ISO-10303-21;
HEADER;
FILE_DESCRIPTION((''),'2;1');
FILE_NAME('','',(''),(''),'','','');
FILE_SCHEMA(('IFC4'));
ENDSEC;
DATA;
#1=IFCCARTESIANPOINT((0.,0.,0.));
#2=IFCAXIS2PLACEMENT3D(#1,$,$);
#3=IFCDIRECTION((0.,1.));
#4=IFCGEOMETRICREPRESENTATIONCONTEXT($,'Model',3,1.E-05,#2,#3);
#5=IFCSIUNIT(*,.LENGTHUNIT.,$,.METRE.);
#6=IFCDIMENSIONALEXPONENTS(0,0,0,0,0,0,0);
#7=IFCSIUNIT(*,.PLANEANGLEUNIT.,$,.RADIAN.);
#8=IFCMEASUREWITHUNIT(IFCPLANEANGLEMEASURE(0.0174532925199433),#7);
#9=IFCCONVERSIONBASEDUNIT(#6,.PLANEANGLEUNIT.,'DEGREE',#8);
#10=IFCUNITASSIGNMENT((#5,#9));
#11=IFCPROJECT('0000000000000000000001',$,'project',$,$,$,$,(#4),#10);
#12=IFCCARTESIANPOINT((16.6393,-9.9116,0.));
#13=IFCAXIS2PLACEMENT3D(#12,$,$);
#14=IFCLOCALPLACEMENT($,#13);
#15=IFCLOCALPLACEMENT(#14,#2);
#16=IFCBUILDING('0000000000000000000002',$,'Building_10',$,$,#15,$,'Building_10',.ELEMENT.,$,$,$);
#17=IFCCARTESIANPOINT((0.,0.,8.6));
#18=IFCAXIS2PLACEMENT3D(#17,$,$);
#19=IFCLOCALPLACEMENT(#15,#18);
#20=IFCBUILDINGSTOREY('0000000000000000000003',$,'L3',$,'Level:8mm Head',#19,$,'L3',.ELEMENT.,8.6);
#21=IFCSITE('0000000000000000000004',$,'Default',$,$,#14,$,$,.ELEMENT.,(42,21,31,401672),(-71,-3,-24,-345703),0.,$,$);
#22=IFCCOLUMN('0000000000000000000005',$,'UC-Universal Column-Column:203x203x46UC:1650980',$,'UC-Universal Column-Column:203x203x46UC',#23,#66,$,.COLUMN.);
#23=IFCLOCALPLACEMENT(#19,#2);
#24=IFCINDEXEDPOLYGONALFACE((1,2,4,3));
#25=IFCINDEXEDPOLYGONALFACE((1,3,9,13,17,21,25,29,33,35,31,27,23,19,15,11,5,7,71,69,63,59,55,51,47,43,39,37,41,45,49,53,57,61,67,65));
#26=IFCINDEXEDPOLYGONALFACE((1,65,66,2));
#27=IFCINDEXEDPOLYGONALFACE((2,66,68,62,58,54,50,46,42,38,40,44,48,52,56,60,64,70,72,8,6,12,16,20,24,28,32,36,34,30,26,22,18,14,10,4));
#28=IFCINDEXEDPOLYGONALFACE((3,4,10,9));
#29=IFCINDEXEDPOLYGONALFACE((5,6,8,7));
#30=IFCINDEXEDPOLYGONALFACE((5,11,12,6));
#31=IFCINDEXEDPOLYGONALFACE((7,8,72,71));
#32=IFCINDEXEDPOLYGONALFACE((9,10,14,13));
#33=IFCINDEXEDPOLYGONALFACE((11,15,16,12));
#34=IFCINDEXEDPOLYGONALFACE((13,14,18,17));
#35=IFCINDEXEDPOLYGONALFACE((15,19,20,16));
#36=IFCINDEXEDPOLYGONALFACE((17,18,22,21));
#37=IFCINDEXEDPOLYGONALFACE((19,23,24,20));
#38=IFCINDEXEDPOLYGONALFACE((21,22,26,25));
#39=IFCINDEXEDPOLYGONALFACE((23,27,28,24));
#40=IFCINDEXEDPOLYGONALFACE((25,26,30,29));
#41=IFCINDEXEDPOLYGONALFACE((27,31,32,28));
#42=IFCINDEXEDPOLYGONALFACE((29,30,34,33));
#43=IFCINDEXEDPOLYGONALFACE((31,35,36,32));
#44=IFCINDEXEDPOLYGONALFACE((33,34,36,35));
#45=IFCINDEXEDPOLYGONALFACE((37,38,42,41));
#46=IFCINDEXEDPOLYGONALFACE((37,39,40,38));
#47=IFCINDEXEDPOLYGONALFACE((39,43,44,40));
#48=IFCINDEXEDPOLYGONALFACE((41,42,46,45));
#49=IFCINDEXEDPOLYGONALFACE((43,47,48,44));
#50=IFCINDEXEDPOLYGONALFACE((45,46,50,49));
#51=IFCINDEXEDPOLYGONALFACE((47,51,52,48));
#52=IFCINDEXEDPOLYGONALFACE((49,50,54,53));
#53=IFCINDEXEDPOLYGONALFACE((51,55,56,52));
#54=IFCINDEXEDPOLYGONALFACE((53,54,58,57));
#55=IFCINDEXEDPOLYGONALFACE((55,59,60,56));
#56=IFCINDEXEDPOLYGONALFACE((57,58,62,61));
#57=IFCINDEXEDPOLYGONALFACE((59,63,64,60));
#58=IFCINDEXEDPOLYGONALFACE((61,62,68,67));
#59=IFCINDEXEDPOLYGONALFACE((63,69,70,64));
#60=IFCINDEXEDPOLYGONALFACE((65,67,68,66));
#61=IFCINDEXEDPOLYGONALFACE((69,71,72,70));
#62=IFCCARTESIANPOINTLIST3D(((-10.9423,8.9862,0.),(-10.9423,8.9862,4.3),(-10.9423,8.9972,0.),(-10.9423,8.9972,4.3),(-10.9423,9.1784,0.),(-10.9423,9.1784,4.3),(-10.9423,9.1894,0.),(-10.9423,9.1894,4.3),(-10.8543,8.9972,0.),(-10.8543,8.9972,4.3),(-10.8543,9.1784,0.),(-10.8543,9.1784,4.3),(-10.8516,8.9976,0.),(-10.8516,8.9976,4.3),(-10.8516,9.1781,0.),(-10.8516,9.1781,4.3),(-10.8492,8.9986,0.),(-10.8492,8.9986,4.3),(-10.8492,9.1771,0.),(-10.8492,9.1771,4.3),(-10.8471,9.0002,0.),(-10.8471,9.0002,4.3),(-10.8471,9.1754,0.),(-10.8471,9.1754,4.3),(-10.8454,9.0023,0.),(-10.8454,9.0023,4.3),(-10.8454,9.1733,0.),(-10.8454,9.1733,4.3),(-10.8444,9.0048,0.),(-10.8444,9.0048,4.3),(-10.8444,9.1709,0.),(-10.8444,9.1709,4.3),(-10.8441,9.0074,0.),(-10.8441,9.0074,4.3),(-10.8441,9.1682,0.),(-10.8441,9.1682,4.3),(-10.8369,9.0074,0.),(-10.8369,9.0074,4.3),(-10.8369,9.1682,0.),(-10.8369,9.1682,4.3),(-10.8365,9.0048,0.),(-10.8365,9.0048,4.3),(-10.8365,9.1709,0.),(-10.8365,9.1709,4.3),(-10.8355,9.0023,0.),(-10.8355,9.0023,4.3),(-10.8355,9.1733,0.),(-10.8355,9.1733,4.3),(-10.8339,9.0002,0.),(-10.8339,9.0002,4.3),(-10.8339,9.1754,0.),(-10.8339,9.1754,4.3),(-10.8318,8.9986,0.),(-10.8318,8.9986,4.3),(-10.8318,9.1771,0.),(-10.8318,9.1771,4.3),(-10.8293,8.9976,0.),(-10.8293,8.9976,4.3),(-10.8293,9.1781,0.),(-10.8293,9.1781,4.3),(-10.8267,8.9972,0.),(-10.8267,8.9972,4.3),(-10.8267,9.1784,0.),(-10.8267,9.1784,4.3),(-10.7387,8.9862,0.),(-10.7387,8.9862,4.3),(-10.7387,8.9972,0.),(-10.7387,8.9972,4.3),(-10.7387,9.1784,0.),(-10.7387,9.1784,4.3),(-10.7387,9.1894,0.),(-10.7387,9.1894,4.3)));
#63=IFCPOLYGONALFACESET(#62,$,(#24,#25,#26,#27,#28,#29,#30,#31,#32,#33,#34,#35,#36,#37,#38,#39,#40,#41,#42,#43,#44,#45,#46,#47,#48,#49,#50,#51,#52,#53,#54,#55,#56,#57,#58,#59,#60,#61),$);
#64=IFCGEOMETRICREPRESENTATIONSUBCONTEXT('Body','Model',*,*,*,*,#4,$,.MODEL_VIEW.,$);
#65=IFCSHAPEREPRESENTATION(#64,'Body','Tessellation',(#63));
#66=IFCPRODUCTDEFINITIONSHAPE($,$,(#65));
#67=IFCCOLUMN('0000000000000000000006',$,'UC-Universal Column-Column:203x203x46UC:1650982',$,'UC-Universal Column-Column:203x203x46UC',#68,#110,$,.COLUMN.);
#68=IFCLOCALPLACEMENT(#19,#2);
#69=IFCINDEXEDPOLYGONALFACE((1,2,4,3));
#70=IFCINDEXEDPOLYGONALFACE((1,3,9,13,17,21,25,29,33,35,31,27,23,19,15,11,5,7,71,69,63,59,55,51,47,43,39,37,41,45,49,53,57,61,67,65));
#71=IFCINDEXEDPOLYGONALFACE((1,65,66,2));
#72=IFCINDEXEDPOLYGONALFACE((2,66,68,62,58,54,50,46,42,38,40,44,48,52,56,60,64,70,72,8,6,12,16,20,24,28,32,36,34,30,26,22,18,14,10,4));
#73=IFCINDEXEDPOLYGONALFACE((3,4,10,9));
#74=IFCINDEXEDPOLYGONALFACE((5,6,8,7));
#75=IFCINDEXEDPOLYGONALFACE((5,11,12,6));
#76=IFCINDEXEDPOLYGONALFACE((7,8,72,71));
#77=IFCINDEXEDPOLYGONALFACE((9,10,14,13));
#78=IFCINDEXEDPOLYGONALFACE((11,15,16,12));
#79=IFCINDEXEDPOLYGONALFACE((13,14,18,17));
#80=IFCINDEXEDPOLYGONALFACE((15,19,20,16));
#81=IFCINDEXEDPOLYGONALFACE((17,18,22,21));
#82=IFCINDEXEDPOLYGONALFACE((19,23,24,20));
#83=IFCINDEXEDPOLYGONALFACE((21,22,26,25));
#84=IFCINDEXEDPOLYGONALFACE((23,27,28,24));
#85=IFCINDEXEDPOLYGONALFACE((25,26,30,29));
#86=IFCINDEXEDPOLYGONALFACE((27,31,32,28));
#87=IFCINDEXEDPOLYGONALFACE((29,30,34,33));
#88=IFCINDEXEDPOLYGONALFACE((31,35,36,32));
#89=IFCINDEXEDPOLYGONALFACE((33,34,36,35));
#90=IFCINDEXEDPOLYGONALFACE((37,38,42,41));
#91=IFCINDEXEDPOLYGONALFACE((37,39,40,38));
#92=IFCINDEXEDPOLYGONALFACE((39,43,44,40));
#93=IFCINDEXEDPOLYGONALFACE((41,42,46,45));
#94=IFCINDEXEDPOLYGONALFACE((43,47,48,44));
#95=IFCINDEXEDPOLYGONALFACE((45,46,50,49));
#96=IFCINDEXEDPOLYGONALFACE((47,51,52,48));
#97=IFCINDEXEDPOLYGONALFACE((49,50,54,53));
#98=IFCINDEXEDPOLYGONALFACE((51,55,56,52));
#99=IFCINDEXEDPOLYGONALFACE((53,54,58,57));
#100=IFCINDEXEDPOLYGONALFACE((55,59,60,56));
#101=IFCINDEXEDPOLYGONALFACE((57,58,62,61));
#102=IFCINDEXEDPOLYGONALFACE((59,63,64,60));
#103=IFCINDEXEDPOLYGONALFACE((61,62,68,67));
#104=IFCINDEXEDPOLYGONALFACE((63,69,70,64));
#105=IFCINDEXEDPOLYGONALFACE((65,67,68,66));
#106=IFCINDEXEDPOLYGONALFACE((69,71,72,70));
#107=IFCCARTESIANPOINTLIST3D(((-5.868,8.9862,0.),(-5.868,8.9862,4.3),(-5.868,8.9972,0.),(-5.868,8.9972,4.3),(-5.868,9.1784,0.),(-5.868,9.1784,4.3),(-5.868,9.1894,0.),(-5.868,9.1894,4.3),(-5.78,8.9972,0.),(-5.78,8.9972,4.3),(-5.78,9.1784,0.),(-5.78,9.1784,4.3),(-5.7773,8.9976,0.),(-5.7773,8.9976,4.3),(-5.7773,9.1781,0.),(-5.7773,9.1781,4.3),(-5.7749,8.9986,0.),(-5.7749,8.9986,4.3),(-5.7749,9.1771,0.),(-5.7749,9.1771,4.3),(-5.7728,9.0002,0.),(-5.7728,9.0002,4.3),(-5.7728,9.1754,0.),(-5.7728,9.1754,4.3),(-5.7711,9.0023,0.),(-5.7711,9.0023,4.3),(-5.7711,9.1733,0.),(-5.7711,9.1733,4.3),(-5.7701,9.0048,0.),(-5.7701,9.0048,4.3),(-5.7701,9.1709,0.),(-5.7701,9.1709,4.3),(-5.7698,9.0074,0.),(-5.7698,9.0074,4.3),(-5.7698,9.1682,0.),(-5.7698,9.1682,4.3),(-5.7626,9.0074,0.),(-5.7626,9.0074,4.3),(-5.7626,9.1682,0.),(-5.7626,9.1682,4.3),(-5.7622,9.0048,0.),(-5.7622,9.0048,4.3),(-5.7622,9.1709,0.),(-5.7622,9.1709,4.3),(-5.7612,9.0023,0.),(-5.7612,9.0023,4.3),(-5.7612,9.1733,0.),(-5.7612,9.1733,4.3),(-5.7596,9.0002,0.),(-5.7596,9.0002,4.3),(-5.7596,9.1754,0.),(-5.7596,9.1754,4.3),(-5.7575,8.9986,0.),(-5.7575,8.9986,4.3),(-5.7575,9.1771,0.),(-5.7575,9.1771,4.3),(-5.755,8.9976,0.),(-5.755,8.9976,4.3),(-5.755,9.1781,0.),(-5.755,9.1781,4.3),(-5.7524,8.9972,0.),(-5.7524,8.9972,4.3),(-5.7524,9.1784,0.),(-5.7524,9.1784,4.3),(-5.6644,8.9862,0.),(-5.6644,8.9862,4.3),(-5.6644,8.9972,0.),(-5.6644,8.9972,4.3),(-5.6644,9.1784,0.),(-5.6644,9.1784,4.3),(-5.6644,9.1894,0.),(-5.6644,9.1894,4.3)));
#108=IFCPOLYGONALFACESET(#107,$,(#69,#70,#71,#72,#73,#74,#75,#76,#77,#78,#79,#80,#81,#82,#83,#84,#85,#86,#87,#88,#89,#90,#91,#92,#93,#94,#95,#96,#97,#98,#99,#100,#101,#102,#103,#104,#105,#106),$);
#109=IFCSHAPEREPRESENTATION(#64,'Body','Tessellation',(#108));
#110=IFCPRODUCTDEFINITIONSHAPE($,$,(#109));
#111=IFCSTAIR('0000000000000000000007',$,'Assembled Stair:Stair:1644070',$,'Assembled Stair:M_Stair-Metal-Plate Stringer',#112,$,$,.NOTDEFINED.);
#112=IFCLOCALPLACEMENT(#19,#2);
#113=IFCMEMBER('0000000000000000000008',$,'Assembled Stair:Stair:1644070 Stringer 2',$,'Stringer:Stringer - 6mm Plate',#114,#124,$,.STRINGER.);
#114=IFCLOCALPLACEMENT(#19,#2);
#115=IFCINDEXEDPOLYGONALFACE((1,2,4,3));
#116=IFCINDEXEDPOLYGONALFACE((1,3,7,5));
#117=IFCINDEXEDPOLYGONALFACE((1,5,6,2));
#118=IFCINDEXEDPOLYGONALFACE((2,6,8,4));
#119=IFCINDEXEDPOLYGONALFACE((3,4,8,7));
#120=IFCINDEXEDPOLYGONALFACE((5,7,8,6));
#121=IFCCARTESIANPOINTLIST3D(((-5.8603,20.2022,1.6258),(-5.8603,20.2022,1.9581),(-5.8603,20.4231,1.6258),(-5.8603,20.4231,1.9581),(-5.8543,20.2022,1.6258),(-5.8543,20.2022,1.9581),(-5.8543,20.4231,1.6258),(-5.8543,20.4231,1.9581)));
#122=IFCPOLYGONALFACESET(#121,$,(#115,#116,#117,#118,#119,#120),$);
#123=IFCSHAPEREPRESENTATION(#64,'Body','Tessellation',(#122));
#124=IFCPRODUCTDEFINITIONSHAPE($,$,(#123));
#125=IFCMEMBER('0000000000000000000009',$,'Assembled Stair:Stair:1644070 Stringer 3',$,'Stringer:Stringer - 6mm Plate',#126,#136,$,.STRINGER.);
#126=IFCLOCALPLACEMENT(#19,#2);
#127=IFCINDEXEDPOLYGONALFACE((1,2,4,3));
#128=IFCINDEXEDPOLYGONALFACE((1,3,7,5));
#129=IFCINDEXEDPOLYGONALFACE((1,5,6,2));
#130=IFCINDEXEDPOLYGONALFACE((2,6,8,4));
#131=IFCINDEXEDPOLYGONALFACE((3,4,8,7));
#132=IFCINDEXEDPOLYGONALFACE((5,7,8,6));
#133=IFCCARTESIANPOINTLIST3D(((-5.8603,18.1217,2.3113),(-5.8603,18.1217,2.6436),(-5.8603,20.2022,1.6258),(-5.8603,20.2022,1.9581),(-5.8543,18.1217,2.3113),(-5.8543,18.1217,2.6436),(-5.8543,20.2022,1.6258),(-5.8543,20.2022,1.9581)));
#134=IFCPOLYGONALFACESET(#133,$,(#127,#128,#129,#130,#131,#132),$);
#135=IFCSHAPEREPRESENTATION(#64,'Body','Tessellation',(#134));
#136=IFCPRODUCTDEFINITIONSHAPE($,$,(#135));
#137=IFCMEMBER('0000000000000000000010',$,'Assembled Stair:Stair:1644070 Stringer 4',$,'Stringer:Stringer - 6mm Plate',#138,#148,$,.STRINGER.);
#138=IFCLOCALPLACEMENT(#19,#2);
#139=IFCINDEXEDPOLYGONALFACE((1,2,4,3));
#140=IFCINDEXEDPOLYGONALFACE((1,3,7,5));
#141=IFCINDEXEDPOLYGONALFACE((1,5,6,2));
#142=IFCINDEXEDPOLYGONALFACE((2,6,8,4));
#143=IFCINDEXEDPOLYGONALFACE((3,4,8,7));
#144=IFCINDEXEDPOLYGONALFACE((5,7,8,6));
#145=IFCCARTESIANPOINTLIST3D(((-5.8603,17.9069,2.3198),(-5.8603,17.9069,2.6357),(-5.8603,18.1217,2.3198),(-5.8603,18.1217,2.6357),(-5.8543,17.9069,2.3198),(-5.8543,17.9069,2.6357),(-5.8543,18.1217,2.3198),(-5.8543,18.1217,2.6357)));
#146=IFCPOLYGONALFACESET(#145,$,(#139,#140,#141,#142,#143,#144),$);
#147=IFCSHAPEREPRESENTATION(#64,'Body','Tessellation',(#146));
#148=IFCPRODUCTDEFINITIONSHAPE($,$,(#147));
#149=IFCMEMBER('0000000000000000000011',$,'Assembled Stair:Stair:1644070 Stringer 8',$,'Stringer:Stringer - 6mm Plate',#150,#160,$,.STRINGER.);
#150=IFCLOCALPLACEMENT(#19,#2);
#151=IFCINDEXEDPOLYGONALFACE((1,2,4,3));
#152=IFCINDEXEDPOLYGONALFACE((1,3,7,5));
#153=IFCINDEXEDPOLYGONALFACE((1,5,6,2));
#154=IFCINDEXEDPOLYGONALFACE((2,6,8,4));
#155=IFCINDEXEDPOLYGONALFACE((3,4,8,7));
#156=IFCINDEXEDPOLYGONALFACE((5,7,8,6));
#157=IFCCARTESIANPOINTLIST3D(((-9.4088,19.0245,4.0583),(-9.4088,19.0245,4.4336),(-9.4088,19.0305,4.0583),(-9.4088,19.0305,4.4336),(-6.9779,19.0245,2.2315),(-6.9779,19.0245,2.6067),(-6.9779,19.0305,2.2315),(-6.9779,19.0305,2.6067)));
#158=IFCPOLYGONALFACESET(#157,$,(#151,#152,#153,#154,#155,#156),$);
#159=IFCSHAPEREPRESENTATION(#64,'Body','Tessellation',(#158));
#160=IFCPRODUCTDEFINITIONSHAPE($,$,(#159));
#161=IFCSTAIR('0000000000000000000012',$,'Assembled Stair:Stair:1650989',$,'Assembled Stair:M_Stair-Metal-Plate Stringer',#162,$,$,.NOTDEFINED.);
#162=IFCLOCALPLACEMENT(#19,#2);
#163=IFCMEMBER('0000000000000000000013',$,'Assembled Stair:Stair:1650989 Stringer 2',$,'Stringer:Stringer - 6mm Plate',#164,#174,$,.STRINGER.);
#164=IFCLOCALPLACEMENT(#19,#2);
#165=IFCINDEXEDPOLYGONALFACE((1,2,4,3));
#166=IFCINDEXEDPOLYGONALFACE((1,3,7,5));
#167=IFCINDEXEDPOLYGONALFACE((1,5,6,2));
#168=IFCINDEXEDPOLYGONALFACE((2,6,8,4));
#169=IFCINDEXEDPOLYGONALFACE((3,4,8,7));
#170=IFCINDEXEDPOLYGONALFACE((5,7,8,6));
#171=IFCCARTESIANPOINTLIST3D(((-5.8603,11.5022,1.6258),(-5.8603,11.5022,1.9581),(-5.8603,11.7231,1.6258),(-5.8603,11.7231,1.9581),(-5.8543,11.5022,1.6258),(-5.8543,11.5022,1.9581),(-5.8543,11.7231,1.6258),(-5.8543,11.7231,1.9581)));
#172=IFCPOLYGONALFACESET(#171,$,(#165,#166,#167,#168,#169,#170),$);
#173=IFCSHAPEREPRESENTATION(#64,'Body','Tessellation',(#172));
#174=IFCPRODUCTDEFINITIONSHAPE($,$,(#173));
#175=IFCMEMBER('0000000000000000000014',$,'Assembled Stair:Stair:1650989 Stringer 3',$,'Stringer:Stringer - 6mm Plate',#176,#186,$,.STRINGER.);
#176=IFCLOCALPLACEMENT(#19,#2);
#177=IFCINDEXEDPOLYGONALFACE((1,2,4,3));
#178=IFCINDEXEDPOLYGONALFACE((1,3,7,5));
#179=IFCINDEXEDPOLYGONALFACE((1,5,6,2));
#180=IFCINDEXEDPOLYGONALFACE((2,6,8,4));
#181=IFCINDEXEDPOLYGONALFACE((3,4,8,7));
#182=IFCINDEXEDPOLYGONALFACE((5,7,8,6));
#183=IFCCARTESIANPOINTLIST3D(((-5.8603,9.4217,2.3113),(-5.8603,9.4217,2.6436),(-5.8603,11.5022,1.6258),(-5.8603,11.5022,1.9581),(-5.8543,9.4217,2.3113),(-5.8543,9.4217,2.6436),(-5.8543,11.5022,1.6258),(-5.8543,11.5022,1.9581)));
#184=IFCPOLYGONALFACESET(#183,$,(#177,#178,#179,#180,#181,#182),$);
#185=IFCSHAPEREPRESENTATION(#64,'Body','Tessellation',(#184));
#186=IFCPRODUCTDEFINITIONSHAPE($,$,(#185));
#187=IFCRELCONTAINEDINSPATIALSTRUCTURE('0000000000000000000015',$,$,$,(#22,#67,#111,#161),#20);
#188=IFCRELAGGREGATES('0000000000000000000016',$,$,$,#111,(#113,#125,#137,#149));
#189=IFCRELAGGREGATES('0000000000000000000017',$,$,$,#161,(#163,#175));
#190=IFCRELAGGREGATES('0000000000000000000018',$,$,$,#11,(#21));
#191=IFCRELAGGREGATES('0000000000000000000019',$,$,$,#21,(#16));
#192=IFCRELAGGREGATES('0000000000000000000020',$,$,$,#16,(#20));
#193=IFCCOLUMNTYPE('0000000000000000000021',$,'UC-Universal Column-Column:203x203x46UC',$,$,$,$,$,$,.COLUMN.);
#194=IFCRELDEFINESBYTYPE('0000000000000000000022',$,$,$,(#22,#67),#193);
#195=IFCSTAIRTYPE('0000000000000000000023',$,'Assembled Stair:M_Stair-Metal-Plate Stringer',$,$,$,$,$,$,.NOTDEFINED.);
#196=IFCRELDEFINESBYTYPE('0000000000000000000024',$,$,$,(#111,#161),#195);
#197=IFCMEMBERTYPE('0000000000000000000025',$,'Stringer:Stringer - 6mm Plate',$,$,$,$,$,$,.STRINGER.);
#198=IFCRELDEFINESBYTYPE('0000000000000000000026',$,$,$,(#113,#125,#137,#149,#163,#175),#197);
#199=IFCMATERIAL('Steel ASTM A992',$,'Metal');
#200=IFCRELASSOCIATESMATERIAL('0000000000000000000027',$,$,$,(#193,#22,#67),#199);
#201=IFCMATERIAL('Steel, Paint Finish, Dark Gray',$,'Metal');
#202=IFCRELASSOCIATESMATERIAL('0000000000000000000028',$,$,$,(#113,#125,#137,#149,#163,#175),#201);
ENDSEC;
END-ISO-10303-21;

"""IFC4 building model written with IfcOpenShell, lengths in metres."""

from ifc_helpers import new_model, entity, si_unit, converted_unit, direction, frame, origin, place, context, subcontext, project, spatial, line, arc, indexed_curve, outline, extrude, source, transform, mapped, material, type_object, type_shapes, element, aggregate, save


model = new_model("IFC4")

# Units and contexts
model_context = context("Model", 3, precision=1e-05, world=origin(), true_north=direction((0.0, 1.0)))
body_context = subcontext(model_context, "Body", "Model", "MODEL_VIEW")
ifc_project = project(units=[si_unit("LENGTHUNIT", "METRE"), converted_unit("PLANEANGLEUNIT", "DEGREE", entity("IfcPlaneAngleMeasure", 0.0174532925199433), si_unit("PLANEANGLEUNIT", "RADIAN"), dimensions=[0, 0, 0, 0, 0, 0, 0])], contexts=[model_context])

# Site, building, storey
site_placement = place(None, frame((16.6393, -9.9116, 0.0)))
site = spatial("IfcSite", under=ifc_project, at=site_placement, Name="Default", CompositionType="ELEMENT", RefLatitude=(42, 21, 31, 401672), RefLongitude=(-71, -3, -24, -345703), RefElevation=0.0)
building_placement = place(site_placement, origin())
building = spatial("IfcBuilding", under=site, at=building_placement, Name="Building_10", LongName="Building_10", CompositionType="ELEMENT")
storey_placement = place(building_placement, frame((0.0, 0.0, 8.6)))
storey = spatial("IfcBuildingStorey", under=building, at=storey_placement, Name="L3", ObjectType="Level:8mm Head", LongName="L3", CompositionType="ELEMENT", Elevation=8.6)

# Columns
ifc_material_1 = material(Name="Steel ASTM A992", Category="Metal")
column_type = type_object("IfcColumnType", Name="UC-Universal Column-Column:203x203x46UC", PredefinedType="COLUMN", material=ifc_material_1)
shared_shape_1 = source(origin(), body_context, "Body", "SweptSolid", [
    extrude(outline(indexed_curve([(-0.1018, -0.1016), (0.1018, -0.1016), (0.1018, -0.0906), (0.0138, -0.0906), (0.0066, -0.0876), (0.0036, -0.0804), (0.0036, 0.0804), (0.0066, 0.0876), (0.0138, 0.0906), (0.1018, 0.0906), (0.1018, 0.1016), (-0.1018, 0.1016), (-0.1018, 0.0906), (-0.0138, 0.0906), (-0.0066, 0.0876), (-0.0036, 0.0804), (-0.0036, -0.0804), (-0.0066, -0.0876), (-0.0138, -0.0906), (-0.1018, -0.0906)], segments=[line(1, 2, 3, 4), arc(4, 5, 6), line(6, 7), arc(7, 8, 9), line(9, 10, 11, 12, 13, 14), arc(14, 15, 16), line(16, 17), arc(17, 18, 19), line(19, 20, 1)], self_intersect=False)), frame((0.0, 0.0, 8.6), z_axis=(0.0, 0.0, 1.0), x_axis=(-1.0, 0.0, 0.0)), (0.0, 0.0, 1.0), 4.3),
])
type_shapes(column_type, [shared_shape_1])
for number, where, name in (
    (1, (-10.8405, 9.0878, -8.6), "UC-Universal Column-Column:203x203x46UC:1650980"),
    (2, (-5.7662, 9.0878, -8.6), "UC-Universal Column-Column:203x203x46UC:1650982"),
):
    element("IfcColumn", number, at=place(storey_placement, frame(where)), inside=storey, type_object=column_type, material=ifc_material_1, Name=name, ObjectType="UC-Universal Column-Column:203x203x46UC", PredefinedType="COLUMN", context=body_context, shape_type="MappedRepresentation", body=[
        mapped(shared_shape_1, transform((0.0, 0.0, 0.0), scale=1.0)),
    ])

# Stairs, members
stair_type = type_object("IfcStairType", Name="Assembled Stair:M_Stair-Metal-Plate Stringer", PredefinedType="NOTDEFINED")
stair_1_placement = place(storey_placement, origin())
stair_1 = element("IfcStair", 3, at=stair_1_placement, inside=storey, type_object=stair_type, Name="Assembled Stair:Stair:1644070", ObjectType="Assembled Stair:M_Stair-Metal-Plate Stringer", PredefinedType="NOTDEFINED")
ifc_material_2 = material(Name="Steel, Paint Finish, Dark Gray", Category="Metal")
member_type = type_object("IfcMemberType", Name="Stringer:Stringer - 6mm Plate", PredefinedType="STRINGER")
member_1_placement = place(stair_1_placement, origin())
member_1 = element("IfcMember", 4, at=member_1_placement, type_object=member_type, material=ifc_material_2, Name="Assembled Stair:Stair:1644070 Stringer 2", ObjectType="Stringer:Stringer - 6mm Plate", PredefinedType="STRINGER", context=body_context, shape_type="SweptSolid", body=[
    extrude(outline(indexed_curve([(-0.1104, -0.003), (0.1104, -0.003), (0.1104, 0.003), (-0.1104, 0.003), (-0.1104, -0.003)], self_intersect=False)), frame((-5.8573, 20.3126, 1.6258), z_axis=(0.0, 0.0, 1.0), x_axis=(0.0, -1.0, 0.0)), (0.0, 0.0, 1.0), 0.3323),
])
member_2_placement = place(stair_1_placement, origin())
member_2 = element("IfcMember", 5, at=member_2_placement, type_object=member_type, material=ifc_material_2, Name="Assembled Stair:Stair:1644070 Stringer 3", ObjectType="Stringer:Stringer - 6mm Plate", PredefinedType="STRINGER", context=body_context, shape_type="SweptSolid", body=[
    extrude(outline(indexed_curve([(-1.0433, -0.1578), (1.1473, -0.1578), (1.0433, 0.1578), (-1.1473, 0.1578), (-1.0433, -0.1578)], self_intersect=False)), frame((-5.8603, 19.162, 2.1347), z_axis=(1.0, 0.0, 0.0), x_axis=(0.0, -0.949774, 0.312936)), (0.0, 0.0, 1.0), 0.006),
])
member_3_placement = place(stair_1_placement, origin())
member_3 = element("IfcMember", 6, at=member_3_placement, type_object=member_type, material=ifc_material_2, Name="Assembled Stair:Stair:1644070 Stringer 4", ObjectType="Stringer:Stringer - 6mm Plate", PredefinedType="STRINGER", context=body_context, shape_type="SweptSolid", body=[
    extrude(outline(indexed_curve([(-0.1074, -0.003), (0.1074, -0.003), (0.1074, 0.003), (-0.1074, 0.003), (-0.1074, -0.003)], self_intersect=False)), frame((-5.8573, 18.0143, 2.3198), z_axis=(0.0, 0.0, 1.0), x_axis=(0.0, -1.0, 0.0)), (0.0, 0.0, 1.0), 0.3159),
])
member_4_placement = place(stair_1_placement, origin())
member_4 = element("IfcMember", 7, at=member_4_placement, type_object=member_type, material=ifc_material_2, Name="Assembled Stair:Stair:1644070 Stringer 8", ObjectType="Stringer:Stringer - 6mm Plate", PredefinedType="STRINGER", context=body_context, shape_type="SweptSolid", body=[
    extrude(outline(indexed_curve([(-1.6331, -0.15), (1.4077, -0.15), (1.6331, 0.15), (-1.4077, 0.15), (-1.6331, -0.15)], self_intersect=False)), frame((-8.1933, 19.0245, 3.3325), z_axis=(0.0, 1.0, 0.0), x_axis=(-0.799415, 0.0, 0.600779)), (0.0, 0.0, 1.0), 0.006),
])
aggregate(stair_1, [member_1, member_2, member_3, member_4])
stair_2_placement = place(storey_placement, origin())
stair_2 = element("IfcStair", 8, at=stair_2_placement, inside=storey, type_object=stair_type, Name="Assembled Stair:Stair:1650989", ObjectType="Assembled Stair:M_Stair-Metal-Plate Stringer", PredefinedType="NOTDEFINED")
member_5_placement = place(stair_2_placement, origin())
member_5 = element("IfcMember", 9, at=member_5_placement, type_object=member_type, material=ifc_material_2, Name="Assembled Stair:Stair:1650989 Stringer 2", ObjectType="Stringer:Stringer - 6mm Plate", PredefinedType="STRINGER", context=body_context, shape_type="SweptSolid", body=[
    extrude(outline(indexed_curve([(-0.1104, -0.003), (0.1104, -0.003), (0.1104, 0.003), (-0.1104, 0.003), (-0.1104, -0.003)], self_intersect=False)), frame((-5.8573, 11.6126, 1.6258), z_axis=(0.0, 0.0, 1.0), x_axis=(0.0, -1.0, 0.0)), (0.0, 0.0, 1.0), 0.3323),
])
member_6_placement = place(stair_2_placement, origin())
member_6 = element("IfcMember", 10, at=member_6_placement, type_object=member_type, material=ifc_material_2, Name="Assembled Stair:Stair:1650989 Stringer 3", ObjectType="Stringer:Stringer - 6mm Plate", PredefinedType="STRINGER", context=body_context, shape_type="SweptSolid", body=[
    extrude(outline(indexed_curve([(-1.0433, -0.1578), (1.1473, -0.1578), (1.0433, 0.1578), (-1.1473, 0.1578), (-1.0433, -0.1578)], self_intersect=False)), frame((-5.8603, 10.462, 2.1347), z_axis=(1.0, 0.0, 0.0), x_axis=(0.0, -0.949774, 0.312936)), (0.0, 0.0, 1.0), 0.006),
])
aggregate(stair_2, [member_5, member_6])

save(model, "model.ifc")
